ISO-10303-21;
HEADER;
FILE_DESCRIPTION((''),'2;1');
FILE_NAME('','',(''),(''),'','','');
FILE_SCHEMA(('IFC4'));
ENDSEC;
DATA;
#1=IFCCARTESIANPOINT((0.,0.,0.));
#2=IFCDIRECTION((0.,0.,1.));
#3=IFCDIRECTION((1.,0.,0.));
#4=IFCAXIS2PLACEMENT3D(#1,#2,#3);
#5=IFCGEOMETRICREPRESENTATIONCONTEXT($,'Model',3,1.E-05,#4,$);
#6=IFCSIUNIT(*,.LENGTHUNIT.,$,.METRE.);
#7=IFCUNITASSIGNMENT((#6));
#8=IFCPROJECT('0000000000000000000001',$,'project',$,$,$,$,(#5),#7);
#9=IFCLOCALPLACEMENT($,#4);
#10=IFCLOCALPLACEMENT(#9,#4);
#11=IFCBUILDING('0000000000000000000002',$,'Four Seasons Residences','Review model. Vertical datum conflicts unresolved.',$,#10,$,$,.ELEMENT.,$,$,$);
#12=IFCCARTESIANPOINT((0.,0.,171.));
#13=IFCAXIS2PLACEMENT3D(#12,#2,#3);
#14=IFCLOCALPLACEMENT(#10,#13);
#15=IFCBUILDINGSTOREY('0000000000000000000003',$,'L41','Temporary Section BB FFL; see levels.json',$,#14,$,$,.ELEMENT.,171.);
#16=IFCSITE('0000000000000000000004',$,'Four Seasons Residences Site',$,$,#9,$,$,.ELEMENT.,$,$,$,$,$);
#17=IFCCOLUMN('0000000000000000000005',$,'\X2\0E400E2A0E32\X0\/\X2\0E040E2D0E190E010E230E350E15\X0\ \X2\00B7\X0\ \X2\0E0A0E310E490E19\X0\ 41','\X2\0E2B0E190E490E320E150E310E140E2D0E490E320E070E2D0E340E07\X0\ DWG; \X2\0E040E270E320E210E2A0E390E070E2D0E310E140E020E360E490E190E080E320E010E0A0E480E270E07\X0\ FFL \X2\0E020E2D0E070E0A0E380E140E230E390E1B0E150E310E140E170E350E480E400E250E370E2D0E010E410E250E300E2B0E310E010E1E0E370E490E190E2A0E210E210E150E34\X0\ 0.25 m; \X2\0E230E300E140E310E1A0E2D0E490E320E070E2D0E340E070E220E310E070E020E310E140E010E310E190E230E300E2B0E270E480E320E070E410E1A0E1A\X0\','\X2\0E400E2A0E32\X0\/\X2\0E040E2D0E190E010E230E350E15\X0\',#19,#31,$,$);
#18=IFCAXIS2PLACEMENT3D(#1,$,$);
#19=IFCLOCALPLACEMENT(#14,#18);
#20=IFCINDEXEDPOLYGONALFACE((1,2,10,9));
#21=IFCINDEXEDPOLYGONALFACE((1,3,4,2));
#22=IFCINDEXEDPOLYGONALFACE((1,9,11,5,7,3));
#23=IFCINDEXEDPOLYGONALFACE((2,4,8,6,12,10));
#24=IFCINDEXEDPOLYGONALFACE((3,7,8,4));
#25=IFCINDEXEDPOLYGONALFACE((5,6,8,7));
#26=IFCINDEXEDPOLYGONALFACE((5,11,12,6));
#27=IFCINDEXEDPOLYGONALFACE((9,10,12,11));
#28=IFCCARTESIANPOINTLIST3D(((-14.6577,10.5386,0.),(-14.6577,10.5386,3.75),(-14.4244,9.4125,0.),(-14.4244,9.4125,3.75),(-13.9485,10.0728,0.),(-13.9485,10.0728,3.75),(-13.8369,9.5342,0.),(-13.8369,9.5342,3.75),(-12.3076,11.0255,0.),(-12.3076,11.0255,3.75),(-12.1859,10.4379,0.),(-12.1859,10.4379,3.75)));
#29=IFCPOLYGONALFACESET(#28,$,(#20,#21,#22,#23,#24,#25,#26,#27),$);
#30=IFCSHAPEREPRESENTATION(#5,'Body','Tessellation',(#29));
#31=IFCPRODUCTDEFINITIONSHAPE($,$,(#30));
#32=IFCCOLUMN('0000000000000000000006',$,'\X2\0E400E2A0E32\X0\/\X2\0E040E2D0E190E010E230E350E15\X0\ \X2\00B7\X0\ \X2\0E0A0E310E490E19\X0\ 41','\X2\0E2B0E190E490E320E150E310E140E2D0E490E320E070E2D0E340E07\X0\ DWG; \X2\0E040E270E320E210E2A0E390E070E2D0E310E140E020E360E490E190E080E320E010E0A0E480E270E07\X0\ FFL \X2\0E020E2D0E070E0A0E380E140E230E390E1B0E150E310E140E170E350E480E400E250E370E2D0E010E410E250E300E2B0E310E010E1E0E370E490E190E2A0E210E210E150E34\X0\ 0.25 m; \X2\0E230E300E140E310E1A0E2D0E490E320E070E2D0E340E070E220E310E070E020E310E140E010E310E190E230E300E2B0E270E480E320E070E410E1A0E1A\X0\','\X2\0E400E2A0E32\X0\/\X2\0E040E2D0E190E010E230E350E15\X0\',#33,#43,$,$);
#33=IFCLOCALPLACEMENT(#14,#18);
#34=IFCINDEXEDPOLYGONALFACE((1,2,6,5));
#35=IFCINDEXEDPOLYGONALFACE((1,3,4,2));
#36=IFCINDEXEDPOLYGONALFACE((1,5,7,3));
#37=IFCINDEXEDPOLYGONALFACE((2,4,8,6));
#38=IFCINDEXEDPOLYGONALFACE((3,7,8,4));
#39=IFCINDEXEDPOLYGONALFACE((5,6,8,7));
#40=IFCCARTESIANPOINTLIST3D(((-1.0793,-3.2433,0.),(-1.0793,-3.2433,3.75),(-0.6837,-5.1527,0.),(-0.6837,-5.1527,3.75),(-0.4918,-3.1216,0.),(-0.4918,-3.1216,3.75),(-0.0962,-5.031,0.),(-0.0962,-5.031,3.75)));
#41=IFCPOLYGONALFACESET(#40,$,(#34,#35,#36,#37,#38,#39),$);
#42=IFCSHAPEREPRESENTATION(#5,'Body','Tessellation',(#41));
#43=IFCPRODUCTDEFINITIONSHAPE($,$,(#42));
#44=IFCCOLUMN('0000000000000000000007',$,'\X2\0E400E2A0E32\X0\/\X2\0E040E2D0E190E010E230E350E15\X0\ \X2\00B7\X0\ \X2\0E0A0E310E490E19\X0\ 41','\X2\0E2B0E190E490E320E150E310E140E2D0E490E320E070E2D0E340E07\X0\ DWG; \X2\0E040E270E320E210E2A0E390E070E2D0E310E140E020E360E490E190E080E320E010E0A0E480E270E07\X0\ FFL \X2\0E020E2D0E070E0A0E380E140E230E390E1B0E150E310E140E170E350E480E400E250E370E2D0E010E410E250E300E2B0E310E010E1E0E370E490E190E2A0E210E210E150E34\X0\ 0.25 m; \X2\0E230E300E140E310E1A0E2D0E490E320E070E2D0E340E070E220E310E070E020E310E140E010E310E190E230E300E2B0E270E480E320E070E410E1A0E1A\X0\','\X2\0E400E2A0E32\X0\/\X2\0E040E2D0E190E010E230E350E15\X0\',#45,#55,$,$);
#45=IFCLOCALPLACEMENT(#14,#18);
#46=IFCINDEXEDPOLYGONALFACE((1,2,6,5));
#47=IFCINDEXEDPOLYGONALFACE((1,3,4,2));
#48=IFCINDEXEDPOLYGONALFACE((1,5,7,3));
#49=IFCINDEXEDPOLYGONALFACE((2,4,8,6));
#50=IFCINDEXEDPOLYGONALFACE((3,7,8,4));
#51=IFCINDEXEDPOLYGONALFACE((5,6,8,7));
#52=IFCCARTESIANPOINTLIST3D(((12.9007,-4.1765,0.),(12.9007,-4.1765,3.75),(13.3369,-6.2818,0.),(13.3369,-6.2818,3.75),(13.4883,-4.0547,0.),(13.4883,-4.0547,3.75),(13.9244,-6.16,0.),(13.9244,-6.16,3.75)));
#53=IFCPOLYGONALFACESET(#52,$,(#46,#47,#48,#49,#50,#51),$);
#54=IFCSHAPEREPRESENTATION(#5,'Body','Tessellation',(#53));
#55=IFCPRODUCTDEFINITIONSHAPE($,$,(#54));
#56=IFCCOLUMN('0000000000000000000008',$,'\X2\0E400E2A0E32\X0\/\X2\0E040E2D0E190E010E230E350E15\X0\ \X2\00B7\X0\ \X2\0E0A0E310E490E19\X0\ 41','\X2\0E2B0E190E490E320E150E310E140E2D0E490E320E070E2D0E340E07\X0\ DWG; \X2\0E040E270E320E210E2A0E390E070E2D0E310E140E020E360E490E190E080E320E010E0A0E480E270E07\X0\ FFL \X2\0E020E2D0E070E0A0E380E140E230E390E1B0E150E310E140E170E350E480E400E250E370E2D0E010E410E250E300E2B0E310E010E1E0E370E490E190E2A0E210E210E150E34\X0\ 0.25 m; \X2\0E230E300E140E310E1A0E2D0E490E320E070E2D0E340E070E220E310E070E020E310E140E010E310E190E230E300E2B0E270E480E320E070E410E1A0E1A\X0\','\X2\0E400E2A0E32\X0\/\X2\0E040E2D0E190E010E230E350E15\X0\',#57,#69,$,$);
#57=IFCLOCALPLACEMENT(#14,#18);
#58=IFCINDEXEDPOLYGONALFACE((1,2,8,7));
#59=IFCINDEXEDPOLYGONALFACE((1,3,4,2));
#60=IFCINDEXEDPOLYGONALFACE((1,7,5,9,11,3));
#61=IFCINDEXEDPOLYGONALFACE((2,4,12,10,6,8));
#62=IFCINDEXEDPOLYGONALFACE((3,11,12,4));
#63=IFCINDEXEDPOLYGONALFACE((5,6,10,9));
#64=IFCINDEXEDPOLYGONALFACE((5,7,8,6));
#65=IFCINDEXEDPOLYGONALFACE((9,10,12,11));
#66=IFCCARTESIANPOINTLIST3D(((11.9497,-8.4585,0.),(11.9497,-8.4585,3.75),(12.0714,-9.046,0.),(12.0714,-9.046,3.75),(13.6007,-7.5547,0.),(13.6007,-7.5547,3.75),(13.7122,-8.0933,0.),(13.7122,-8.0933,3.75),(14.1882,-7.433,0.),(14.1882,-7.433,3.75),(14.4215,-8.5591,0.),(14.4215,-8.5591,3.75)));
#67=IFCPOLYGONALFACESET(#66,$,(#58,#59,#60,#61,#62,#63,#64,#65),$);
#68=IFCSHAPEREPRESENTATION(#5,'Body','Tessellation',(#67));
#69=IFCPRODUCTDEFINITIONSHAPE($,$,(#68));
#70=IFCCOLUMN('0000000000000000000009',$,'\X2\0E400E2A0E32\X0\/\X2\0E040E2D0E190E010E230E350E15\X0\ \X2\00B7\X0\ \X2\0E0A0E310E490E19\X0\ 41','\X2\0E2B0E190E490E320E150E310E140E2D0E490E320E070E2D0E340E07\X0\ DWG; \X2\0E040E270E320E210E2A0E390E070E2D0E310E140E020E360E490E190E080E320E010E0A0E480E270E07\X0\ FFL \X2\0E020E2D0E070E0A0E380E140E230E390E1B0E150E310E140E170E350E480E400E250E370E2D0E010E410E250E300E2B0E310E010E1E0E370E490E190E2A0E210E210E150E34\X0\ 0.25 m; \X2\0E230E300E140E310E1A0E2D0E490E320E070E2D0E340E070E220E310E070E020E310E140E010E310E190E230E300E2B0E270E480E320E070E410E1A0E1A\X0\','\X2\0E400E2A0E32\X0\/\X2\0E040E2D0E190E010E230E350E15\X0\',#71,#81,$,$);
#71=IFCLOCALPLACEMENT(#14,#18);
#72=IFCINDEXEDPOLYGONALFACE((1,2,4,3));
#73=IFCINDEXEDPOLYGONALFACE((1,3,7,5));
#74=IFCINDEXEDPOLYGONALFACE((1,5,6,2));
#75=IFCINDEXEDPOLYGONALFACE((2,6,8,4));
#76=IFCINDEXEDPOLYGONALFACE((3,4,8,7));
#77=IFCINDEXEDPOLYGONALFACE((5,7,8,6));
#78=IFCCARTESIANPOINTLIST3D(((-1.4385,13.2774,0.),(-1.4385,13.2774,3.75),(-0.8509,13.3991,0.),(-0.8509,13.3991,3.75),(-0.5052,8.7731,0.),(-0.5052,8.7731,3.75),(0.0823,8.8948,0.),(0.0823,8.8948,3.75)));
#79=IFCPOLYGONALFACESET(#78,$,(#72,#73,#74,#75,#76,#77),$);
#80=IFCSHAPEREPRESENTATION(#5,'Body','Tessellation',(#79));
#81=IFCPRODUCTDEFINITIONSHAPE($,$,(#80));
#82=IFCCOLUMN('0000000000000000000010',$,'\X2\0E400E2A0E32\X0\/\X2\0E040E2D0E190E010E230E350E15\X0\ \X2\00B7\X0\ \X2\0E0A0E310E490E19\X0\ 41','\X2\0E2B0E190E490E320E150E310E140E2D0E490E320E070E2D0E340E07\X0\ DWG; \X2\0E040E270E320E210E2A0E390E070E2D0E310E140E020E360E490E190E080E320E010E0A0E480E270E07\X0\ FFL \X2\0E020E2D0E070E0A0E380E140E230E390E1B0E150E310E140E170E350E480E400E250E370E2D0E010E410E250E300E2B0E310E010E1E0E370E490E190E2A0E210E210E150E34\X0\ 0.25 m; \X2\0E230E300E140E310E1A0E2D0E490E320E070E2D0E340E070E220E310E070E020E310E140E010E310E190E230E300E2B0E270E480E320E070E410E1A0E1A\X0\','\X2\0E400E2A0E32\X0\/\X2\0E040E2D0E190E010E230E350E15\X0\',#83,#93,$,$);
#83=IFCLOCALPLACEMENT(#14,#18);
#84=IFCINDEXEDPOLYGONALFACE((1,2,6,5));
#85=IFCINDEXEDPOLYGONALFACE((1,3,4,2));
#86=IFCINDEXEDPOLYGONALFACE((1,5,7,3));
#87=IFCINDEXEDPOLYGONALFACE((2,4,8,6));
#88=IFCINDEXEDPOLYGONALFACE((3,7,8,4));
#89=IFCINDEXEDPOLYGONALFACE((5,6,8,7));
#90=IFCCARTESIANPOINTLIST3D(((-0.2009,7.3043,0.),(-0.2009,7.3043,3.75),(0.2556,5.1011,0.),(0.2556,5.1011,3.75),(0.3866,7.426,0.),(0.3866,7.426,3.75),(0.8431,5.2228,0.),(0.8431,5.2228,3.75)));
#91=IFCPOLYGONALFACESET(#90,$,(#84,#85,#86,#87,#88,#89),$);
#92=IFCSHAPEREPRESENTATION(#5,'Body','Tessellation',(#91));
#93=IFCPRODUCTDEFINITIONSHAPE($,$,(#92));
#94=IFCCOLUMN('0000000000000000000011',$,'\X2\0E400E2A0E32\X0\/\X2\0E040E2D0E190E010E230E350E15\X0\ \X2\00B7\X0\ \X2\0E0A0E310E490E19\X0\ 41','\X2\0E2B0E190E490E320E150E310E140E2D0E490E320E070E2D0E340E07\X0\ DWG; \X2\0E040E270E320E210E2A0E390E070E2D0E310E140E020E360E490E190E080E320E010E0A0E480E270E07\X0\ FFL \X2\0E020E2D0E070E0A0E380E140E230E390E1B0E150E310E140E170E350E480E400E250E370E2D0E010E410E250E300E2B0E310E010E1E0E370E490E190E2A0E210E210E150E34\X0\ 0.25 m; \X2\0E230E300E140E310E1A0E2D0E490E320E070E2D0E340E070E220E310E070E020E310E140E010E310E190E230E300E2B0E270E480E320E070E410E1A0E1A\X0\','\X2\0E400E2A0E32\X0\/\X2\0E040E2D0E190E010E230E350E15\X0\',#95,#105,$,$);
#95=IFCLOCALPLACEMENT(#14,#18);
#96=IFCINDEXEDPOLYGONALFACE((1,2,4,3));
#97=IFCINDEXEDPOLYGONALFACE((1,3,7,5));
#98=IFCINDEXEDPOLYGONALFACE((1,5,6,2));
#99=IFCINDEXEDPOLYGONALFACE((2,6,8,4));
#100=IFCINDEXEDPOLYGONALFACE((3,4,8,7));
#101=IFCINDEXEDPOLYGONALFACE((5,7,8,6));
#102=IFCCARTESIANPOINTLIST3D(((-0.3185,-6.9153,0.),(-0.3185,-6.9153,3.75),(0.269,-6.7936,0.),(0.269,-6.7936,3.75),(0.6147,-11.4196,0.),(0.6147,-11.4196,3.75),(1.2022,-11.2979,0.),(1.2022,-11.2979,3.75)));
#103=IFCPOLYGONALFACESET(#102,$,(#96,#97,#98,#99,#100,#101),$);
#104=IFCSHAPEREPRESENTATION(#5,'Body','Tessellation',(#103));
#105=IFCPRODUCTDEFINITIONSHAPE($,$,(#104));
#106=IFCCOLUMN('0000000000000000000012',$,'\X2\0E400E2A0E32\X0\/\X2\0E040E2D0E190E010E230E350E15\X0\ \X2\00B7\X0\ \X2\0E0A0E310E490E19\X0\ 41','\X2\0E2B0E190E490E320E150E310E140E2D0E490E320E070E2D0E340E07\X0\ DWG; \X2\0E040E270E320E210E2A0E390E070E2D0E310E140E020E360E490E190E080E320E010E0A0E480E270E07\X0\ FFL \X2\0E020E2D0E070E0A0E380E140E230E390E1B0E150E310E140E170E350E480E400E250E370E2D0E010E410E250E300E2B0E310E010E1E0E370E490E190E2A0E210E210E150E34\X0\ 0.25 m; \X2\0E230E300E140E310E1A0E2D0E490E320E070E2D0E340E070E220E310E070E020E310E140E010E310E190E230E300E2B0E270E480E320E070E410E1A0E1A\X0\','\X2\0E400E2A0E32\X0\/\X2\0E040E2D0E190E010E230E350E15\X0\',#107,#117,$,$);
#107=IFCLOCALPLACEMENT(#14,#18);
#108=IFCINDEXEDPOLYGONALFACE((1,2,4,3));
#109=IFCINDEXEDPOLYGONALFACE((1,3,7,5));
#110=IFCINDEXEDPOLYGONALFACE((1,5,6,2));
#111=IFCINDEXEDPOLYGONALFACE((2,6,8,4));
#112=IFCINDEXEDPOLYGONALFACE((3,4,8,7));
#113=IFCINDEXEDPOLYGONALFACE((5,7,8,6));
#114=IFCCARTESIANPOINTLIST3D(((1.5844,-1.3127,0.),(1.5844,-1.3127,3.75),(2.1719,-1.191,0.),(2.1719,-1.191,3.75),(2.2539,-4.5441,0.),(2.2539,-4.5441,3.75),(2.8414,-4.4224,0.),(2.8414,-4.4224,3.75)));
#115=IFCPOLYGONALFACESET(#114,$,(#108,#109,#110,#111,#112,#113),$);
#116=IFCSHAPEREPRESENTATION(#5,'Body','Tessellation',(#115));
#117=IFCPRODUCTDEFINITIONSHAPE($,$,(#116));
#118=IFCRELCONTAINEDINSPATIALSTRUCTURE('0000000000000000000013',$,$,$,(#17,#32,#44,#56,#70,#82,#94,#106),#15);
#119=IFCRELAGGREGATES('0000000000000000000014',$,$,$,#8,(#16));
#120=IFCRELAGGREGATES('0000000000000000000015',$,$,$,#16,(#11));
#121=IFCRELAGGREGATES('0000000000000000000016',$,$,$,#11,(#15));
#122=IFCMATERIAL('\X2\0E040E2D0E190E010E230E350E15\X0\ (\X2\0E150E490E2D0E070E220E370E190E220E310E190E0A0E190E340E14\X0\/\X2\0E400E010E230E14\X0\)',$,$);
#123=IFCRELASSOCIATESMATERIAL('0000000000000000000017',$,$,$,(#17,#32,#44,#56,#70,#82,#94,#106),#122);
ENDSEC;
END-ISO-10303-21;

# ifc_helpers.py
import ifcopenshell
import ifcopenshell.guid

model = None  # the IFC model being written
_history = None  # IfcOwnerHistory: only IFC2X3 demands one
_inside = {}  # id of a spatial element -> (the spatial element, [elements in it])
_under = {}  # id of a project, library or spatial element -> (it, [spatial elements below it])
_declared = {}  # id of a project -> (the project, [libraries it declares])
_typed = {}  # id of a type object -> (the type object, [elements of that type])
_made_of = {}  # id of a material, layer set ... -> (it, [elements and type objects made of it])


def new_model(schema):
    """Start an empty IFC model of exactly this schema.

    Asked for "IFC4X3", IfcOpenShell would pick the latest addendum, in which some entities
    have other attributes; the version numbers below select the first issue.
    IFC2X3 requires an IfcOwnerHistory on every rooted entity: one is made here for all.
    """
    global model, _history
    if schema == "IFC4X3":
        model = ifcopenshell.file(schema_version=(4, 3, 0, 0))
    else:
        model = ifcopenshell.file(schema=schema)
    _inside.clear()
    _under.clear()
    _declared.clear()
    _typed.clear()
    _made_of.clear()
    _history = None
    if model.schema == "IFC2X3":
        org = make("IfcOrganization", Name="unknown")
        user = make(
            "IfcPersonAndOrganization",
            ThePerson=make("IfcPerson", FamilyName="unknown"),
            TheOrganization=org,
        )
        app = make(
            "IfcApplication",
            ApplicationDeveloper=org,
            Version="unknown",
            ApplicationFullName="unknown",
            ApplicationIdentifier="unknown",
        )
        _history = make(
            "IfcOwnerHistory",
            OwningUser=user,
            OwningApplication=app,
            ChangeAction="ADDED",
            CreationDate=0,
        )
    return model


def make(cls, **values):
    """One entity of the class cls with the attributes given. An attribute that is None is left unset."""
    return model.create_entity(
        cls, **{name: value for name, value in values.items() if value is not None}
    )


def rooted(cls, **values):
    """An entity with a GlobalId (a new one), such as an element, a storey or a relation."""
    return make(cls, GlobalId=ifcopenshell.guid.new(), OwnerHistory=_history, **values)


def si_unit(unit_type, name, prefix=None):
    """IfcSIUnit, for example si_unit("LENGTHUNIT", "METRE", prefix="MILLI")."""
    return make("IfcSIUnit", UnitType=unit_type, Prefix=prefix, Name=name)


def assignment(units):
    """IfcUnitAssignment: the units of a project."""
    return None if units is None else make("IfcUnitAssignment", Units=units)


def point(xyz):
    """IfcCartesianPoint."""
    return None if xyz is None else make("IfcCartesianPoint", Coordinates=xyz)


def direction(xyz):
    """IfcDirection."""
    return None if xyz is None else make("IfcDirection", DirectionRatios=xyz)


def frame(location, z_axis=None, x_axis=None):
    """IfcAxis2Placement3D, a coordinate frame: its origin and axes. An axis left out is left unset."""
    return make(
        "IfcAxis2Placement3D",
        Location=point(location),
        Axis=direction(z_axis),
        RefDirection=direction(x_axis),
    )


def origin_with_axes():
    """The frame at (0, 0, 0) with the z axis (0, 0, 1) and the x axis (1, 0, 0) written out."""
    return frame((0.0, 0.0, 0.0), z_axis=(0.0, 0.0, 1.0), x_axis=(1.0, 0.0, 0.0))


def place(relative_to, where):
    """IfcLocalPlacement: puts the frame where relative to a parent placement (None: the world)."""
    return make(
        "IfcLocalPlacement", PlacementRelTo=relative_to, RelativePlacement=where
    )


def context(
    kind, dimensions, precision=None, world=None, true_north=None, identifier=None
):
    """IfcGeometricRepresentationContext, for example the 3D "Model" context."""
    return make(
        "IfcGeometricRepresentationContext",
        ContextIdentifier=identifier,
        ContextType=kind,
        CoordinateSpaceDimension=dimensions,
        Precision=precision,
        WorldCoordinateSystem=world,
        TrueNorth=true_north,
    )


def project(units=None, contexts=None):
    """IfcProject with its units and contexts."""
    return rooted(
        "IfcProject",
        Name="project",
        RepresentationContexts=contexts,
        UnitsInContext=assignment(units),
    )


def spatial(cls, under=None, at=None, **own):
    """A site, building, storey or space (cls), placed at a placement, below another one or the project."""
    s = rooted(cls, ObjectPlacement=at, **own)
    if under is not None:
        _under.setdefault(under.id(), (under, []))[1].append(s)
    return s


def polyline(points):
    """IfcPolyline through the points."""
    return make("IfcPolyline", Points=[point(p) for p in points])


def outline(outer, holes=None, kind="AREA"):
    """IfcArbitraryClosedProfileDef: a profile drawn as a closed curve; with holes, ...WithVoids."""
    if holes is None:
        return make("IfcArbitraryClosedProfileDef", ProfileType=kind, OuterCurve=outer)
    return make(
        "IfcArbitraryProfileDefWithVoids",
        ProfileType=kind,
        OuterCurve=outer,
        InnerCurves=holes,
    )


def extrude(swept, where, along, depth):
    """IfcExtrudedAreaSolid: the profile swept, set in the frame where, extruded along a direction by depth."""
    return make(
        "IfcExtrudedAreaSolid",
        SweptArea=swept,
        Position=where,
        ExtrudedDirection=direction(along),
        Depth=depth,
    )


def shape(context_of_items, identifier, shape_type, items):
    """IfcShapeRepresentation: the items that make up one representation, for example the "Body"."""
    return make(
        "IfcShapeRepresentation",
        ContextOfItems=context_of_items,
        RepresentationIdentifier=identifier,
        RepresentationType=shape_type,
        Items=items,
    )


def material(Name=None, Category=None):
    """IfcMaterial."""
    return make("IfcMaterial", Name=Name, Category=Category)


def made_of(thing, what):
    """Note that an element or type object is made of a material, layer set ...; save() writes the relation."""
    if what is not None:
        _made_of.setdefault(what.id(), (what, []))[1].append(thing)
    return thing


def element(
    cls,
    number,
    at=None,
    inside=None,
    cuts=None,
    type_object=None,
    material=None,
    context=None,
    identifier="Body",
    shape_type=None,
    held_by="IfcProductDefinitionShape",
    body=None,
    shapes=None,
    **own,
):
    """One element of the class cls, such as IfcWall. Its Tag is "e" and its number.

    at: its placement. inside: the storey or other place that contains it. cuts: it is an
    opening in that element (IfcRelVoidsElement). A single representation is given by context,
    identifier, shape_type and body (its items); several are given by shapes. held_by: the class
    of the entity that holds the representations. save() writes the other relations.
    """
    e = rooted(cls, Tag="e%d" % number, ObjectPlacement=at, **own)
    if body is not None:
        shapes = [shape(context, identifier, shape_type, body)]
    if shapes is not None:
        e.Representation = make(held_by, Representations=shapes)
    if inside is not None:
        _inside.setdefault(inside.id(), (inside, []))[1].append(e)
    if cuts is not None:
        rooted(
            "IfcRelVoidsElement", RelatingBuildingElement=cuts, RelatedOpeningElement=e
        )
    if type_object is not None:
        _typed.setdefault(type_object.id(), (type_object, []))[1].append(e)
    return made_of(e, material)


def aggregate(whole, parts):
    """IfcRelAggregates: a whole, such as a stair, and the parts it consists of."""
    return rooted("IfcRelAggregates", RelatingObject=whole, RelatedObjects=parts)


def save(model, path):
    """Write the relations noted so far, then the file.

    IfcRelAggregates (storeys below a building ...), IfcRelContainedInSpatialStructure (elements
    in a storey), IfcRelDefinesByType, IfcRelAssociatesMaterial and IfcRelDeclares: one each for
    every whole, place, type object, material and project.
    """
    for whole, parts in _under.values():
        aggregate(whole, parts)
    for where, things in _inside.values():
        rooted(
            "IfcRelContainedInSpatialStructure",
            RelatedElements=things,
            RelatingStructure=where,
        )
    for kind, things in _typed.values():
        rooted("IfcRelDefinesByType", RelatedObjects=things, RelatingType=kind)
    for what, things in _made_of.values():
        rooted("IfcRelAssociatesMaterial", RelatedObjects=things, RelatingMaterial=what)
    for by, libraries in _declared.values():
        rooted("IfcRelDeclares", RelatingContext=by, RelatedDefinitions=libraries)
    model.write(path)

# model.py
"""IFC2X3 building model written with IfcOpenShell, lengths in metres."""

from ifc_helpers import new_model, si_unit, frame, origin_with_axes, place, context, project, spatial, polyline, outline, extrude, material, element, save


model = new_model("IFC2X3")

# Units and contexts
model_context = context("Model", 3, precision=1e-05, world=origin_with_axes())
ifc_project = project(units=[si_unit("LENGTHUNIT", "METRE")], contexts=[model_context])

# Site, building, storey
site_placement = place(None, origin_with_axes())
site = spatial("IfcSite", under=ifc_project, at=site_placement, Name="Four Seasons Residences Site", CompositionType="ELEMENT")
building_placement = place(site_placement, origin_with_axes())
building = spatial("IfcBuilding", under=site, at=building_placement, Name="Four Seasons Residences", Description="Review model. Vertical datum conflicts unresolved.", CompositionType="ELEMENT")
storey_placement = place(building_placement, frame((0.0, 0.0, 171.0), z_axis=(0.0, 0.0, 1.0), x_axis=(1.0, 0.0, 0.0)))
storey = spatial("IfcBuildingStorey", under=building, at=storey_placement, Name="L41", Description="Temporary Section BB FFL; see levels.json", CompositionType="ELEMENT", Elevation=171.0)

# Columns
ifc_material = material(Name="คอนกรีต (ต้องยืนยันชนิด/เกรด)")
column_1_placement = place(storey_placement, origin_with_axes())
element("IfcColumn", 1, at=column_1_placement, inside=storey, material=ifc_material, Name="เสา/คอนกรีต · ชั้น 41", Description="หน้าตัดอ้างอิง DWG; ความสูงอัดขึ้นจากช่วง FFL ของชุดรูปตัดที่เลือกและหักพื้นสมมติ 0.25 m; ระดับอ้างอิงยังขัดกันระหว่างแบบ", ObjectType="เสา/คอนกรีต", context=model_context, shape_type="SweptSolid", body=[
    extrude(outline(polyline([(-14.4244, 9.4125), (-13.8369, 9.5342), (-13.9485, 10.0728), (-12.1859, 10.4379), (-12.3076, 11.0255), (-14.6577, 10.5386), (-14.4244, 9.4125)])), origin_with_axes(), (0.0, 0.0, 1.0), 3.75),
])
column_2_placement = place(storey_placement, origin_with_axes())
element("IfcColumn", 2, at=column_2_placement, inside=storey, material=ifc_material, Name="เสา/คอนกรีต · ชั้น 41", Description="หน้าตัดอ้างอิง DWG; ความสูงอัดขึ้นจากช่วง FFL ของชุดรูปตัดที่เลือกและหักพื้นสมมติ 0.25 m; ระดับอ้างอิงยังขัดกันระหว่างแบบ", ObjectType="เสา/คอนกรีต", context=model_context, shape_type="SweptSolid", body=[
    extrude(outline(polyline([(-0.4918, -3.1216), (-0.0962, -5.031), (-0.6837, -5.1527), (-1.0793, -3.2433), (-0.4918, -3.1216)])), origin_with_axes(), (0.0, 0.0, 1.0), 3.75),
])
column_3_placement = place(storey_placement, origin_with_axes())
element("IfcColumn", 3, at=column_3_placement, inside=storey, material=ifc_material, Name="เสา/คอนกรีต · ชั้น 41", Description="หน้าตัดอ้างอิง DWG; ความสูงอัดขึ้นจากช่วง FFL ของชุดรูปตัดที่เลือกและหักพื้นสมมติ 0.25 m; ระดับอ้างอิงยังขัดกันระหว่างแบบ", ObjectType="เสา/คอนกรีต", context=model_context, shape_type="SweptSolid", body=[
    extrude(outline(polyline([(13.4883, -4.0547), (13.9244, -6.16), (13.3369, -6.2818), (12.9007, -4.1765), (13.4883, -4.0547)])), origin_with_axes(), (0.0, 0.0, 1.0), 3.75),
])
column_4_placement = place(storey_placement, origin_with_axes())
element("IfcColumn", 4, at=column_4_placement, inside=storey, material=ifc_material, Name="เสา/คอนกรีต · ชั้น 41", Description="หน้าตัดอ้างอิง DWG; ความสูงอัดขึ้นจากช่วง FFL ของชุดรูปตัดที่เลือกและหักพื้นสมมติ 0.25 m; ระดับอ้างอิงยังขัดกันระหว่างแบบ", ObjectType="เสา/คอนกรีต", context=model_context, shape_type="SweptSolid", body=[
    extrude(outline(polyline([(12.0714, -9.046), (14.4215, -8.5591), (14.1882, -7.433), (13.6007, -7.5547), (13.7122, -8.0933), (11.9497, -8.4585), (12.0714, -9.046)])), origin_with_axes(), (0.0, 0.0, 1.0), 3.75),
])
column_5_placement = place(storey_placement, origin_with_axes())
element("IfcColumn", 5, at=column_5_placement, inside=storey, material=ifc_material, Name="เสา/คอนกรีต · ชั้น 41", Description="หน้าตัดอ้างอิง DWG; ความสูงอัดขึ้นจากช่วง FFL ของชุดรูปตัดที่เลือกและหักพื้นสมมติ 0.25 m; ระดับอ้างอิงยังขัดกันระหว่างแบบ", ObjectType="เสา/คอนกรีต", context=model_context, shape_type="SweptSolid", body=[
    extrude(outline(polyline([(-0.8509, 13.3991), (0.0823, 8.8948), (-0.5052, 8.7731), (-1.4385, 13.2774), (-0.8509, 13.3991)])), origin_with_axes(), (0.0, 0.0, 1.0), 3.75),
])
column_6_placement = place(storey_placement, origin_with_axes())
element("IfcColumn", 6, at=column_6_placement, inside=storey, material=ifc_material, Name="เสา/คอนกรีต · ชั้น 41", Description="หน้าตัดอ้างอิง DWG; ความสูงอัดขึ้นจากช่วง FFL ของชุดรูปตัดที่เลือกและหักพื้นสมมติ 0.25 m; ระดับอ้างอิงยังขัดกันระหว่างแบบ", ObjectType="เสา/คอนกรีต", context=model_context, shape_type="SweptSolid", body=[
    extrude(outline(polyline([(0.2556, 5.1011), (-0.2009, 7.3043), (0.3866, 7.426), (0.8431, 5.2228), (0.2556, 5.1011)])), origin_with_axes(), (0.0, 0.0, 1.0), 3.75),
])
column_7_placement = place(storey_placement, origin_with_axes())
element("IfcColumn", 7, at=column_7_placement, inside=storey, material=ifc_material, Name="เสา/คอนกรีต · ชั้น 41", Description="หน้าตัดอ้างอิง DWG; ความสูงอัดขึ้นจากช่วง FFL ของชุดรูปตัดที่เลือกและหักพื้นสมมติ 0.25 m; ระดับอ้างอิงยังขัดกันระหว่างแบบ", ObjectType="เสา/คอนกรีต", context=model_context, shape_type="SweptSolid", body=[
    extrude(outline(polyline([(0.269, -6.7936), (1.2022, -11.2979), (0.6147, -11.4196), (-0.3185, -6.9153), (0.269, -6.7936)])), origin_with_axes(), (0.0, 0.0, 1.0), 3.75),
])
column_8_placement = place(storey_placement, origin_with_axes())
element("IfcColumn", 8, at=column_8_placement, inside=storey, material=ifc_material, Name="เสา/คอนกรีต · ชั้น 41", Description="หน้าตัดอ้างอิง DWG; ความสูงอัดขึ้นจากช่วง FFL ของชุดรูปตัดที่เลือกและหักพื้นสมมติ 0.25 m; ระดับอ้างอิงยังขัดกันระหว่างแบบ", ObjectType="เสา/คอนกรีต", context=model_context, shape_type="SweptSolid", body=[
    extrude(outline(polyline([(2.1719, -1.191), (2.8414, -4.4224), (2.2539, -4.5441), (1.5844, -1.3127), (2.1719, -1.191)])), origin_with_axes(), (0.0, 0.0, 1.0), 3.75),
])

save(model, "model.ifc")
